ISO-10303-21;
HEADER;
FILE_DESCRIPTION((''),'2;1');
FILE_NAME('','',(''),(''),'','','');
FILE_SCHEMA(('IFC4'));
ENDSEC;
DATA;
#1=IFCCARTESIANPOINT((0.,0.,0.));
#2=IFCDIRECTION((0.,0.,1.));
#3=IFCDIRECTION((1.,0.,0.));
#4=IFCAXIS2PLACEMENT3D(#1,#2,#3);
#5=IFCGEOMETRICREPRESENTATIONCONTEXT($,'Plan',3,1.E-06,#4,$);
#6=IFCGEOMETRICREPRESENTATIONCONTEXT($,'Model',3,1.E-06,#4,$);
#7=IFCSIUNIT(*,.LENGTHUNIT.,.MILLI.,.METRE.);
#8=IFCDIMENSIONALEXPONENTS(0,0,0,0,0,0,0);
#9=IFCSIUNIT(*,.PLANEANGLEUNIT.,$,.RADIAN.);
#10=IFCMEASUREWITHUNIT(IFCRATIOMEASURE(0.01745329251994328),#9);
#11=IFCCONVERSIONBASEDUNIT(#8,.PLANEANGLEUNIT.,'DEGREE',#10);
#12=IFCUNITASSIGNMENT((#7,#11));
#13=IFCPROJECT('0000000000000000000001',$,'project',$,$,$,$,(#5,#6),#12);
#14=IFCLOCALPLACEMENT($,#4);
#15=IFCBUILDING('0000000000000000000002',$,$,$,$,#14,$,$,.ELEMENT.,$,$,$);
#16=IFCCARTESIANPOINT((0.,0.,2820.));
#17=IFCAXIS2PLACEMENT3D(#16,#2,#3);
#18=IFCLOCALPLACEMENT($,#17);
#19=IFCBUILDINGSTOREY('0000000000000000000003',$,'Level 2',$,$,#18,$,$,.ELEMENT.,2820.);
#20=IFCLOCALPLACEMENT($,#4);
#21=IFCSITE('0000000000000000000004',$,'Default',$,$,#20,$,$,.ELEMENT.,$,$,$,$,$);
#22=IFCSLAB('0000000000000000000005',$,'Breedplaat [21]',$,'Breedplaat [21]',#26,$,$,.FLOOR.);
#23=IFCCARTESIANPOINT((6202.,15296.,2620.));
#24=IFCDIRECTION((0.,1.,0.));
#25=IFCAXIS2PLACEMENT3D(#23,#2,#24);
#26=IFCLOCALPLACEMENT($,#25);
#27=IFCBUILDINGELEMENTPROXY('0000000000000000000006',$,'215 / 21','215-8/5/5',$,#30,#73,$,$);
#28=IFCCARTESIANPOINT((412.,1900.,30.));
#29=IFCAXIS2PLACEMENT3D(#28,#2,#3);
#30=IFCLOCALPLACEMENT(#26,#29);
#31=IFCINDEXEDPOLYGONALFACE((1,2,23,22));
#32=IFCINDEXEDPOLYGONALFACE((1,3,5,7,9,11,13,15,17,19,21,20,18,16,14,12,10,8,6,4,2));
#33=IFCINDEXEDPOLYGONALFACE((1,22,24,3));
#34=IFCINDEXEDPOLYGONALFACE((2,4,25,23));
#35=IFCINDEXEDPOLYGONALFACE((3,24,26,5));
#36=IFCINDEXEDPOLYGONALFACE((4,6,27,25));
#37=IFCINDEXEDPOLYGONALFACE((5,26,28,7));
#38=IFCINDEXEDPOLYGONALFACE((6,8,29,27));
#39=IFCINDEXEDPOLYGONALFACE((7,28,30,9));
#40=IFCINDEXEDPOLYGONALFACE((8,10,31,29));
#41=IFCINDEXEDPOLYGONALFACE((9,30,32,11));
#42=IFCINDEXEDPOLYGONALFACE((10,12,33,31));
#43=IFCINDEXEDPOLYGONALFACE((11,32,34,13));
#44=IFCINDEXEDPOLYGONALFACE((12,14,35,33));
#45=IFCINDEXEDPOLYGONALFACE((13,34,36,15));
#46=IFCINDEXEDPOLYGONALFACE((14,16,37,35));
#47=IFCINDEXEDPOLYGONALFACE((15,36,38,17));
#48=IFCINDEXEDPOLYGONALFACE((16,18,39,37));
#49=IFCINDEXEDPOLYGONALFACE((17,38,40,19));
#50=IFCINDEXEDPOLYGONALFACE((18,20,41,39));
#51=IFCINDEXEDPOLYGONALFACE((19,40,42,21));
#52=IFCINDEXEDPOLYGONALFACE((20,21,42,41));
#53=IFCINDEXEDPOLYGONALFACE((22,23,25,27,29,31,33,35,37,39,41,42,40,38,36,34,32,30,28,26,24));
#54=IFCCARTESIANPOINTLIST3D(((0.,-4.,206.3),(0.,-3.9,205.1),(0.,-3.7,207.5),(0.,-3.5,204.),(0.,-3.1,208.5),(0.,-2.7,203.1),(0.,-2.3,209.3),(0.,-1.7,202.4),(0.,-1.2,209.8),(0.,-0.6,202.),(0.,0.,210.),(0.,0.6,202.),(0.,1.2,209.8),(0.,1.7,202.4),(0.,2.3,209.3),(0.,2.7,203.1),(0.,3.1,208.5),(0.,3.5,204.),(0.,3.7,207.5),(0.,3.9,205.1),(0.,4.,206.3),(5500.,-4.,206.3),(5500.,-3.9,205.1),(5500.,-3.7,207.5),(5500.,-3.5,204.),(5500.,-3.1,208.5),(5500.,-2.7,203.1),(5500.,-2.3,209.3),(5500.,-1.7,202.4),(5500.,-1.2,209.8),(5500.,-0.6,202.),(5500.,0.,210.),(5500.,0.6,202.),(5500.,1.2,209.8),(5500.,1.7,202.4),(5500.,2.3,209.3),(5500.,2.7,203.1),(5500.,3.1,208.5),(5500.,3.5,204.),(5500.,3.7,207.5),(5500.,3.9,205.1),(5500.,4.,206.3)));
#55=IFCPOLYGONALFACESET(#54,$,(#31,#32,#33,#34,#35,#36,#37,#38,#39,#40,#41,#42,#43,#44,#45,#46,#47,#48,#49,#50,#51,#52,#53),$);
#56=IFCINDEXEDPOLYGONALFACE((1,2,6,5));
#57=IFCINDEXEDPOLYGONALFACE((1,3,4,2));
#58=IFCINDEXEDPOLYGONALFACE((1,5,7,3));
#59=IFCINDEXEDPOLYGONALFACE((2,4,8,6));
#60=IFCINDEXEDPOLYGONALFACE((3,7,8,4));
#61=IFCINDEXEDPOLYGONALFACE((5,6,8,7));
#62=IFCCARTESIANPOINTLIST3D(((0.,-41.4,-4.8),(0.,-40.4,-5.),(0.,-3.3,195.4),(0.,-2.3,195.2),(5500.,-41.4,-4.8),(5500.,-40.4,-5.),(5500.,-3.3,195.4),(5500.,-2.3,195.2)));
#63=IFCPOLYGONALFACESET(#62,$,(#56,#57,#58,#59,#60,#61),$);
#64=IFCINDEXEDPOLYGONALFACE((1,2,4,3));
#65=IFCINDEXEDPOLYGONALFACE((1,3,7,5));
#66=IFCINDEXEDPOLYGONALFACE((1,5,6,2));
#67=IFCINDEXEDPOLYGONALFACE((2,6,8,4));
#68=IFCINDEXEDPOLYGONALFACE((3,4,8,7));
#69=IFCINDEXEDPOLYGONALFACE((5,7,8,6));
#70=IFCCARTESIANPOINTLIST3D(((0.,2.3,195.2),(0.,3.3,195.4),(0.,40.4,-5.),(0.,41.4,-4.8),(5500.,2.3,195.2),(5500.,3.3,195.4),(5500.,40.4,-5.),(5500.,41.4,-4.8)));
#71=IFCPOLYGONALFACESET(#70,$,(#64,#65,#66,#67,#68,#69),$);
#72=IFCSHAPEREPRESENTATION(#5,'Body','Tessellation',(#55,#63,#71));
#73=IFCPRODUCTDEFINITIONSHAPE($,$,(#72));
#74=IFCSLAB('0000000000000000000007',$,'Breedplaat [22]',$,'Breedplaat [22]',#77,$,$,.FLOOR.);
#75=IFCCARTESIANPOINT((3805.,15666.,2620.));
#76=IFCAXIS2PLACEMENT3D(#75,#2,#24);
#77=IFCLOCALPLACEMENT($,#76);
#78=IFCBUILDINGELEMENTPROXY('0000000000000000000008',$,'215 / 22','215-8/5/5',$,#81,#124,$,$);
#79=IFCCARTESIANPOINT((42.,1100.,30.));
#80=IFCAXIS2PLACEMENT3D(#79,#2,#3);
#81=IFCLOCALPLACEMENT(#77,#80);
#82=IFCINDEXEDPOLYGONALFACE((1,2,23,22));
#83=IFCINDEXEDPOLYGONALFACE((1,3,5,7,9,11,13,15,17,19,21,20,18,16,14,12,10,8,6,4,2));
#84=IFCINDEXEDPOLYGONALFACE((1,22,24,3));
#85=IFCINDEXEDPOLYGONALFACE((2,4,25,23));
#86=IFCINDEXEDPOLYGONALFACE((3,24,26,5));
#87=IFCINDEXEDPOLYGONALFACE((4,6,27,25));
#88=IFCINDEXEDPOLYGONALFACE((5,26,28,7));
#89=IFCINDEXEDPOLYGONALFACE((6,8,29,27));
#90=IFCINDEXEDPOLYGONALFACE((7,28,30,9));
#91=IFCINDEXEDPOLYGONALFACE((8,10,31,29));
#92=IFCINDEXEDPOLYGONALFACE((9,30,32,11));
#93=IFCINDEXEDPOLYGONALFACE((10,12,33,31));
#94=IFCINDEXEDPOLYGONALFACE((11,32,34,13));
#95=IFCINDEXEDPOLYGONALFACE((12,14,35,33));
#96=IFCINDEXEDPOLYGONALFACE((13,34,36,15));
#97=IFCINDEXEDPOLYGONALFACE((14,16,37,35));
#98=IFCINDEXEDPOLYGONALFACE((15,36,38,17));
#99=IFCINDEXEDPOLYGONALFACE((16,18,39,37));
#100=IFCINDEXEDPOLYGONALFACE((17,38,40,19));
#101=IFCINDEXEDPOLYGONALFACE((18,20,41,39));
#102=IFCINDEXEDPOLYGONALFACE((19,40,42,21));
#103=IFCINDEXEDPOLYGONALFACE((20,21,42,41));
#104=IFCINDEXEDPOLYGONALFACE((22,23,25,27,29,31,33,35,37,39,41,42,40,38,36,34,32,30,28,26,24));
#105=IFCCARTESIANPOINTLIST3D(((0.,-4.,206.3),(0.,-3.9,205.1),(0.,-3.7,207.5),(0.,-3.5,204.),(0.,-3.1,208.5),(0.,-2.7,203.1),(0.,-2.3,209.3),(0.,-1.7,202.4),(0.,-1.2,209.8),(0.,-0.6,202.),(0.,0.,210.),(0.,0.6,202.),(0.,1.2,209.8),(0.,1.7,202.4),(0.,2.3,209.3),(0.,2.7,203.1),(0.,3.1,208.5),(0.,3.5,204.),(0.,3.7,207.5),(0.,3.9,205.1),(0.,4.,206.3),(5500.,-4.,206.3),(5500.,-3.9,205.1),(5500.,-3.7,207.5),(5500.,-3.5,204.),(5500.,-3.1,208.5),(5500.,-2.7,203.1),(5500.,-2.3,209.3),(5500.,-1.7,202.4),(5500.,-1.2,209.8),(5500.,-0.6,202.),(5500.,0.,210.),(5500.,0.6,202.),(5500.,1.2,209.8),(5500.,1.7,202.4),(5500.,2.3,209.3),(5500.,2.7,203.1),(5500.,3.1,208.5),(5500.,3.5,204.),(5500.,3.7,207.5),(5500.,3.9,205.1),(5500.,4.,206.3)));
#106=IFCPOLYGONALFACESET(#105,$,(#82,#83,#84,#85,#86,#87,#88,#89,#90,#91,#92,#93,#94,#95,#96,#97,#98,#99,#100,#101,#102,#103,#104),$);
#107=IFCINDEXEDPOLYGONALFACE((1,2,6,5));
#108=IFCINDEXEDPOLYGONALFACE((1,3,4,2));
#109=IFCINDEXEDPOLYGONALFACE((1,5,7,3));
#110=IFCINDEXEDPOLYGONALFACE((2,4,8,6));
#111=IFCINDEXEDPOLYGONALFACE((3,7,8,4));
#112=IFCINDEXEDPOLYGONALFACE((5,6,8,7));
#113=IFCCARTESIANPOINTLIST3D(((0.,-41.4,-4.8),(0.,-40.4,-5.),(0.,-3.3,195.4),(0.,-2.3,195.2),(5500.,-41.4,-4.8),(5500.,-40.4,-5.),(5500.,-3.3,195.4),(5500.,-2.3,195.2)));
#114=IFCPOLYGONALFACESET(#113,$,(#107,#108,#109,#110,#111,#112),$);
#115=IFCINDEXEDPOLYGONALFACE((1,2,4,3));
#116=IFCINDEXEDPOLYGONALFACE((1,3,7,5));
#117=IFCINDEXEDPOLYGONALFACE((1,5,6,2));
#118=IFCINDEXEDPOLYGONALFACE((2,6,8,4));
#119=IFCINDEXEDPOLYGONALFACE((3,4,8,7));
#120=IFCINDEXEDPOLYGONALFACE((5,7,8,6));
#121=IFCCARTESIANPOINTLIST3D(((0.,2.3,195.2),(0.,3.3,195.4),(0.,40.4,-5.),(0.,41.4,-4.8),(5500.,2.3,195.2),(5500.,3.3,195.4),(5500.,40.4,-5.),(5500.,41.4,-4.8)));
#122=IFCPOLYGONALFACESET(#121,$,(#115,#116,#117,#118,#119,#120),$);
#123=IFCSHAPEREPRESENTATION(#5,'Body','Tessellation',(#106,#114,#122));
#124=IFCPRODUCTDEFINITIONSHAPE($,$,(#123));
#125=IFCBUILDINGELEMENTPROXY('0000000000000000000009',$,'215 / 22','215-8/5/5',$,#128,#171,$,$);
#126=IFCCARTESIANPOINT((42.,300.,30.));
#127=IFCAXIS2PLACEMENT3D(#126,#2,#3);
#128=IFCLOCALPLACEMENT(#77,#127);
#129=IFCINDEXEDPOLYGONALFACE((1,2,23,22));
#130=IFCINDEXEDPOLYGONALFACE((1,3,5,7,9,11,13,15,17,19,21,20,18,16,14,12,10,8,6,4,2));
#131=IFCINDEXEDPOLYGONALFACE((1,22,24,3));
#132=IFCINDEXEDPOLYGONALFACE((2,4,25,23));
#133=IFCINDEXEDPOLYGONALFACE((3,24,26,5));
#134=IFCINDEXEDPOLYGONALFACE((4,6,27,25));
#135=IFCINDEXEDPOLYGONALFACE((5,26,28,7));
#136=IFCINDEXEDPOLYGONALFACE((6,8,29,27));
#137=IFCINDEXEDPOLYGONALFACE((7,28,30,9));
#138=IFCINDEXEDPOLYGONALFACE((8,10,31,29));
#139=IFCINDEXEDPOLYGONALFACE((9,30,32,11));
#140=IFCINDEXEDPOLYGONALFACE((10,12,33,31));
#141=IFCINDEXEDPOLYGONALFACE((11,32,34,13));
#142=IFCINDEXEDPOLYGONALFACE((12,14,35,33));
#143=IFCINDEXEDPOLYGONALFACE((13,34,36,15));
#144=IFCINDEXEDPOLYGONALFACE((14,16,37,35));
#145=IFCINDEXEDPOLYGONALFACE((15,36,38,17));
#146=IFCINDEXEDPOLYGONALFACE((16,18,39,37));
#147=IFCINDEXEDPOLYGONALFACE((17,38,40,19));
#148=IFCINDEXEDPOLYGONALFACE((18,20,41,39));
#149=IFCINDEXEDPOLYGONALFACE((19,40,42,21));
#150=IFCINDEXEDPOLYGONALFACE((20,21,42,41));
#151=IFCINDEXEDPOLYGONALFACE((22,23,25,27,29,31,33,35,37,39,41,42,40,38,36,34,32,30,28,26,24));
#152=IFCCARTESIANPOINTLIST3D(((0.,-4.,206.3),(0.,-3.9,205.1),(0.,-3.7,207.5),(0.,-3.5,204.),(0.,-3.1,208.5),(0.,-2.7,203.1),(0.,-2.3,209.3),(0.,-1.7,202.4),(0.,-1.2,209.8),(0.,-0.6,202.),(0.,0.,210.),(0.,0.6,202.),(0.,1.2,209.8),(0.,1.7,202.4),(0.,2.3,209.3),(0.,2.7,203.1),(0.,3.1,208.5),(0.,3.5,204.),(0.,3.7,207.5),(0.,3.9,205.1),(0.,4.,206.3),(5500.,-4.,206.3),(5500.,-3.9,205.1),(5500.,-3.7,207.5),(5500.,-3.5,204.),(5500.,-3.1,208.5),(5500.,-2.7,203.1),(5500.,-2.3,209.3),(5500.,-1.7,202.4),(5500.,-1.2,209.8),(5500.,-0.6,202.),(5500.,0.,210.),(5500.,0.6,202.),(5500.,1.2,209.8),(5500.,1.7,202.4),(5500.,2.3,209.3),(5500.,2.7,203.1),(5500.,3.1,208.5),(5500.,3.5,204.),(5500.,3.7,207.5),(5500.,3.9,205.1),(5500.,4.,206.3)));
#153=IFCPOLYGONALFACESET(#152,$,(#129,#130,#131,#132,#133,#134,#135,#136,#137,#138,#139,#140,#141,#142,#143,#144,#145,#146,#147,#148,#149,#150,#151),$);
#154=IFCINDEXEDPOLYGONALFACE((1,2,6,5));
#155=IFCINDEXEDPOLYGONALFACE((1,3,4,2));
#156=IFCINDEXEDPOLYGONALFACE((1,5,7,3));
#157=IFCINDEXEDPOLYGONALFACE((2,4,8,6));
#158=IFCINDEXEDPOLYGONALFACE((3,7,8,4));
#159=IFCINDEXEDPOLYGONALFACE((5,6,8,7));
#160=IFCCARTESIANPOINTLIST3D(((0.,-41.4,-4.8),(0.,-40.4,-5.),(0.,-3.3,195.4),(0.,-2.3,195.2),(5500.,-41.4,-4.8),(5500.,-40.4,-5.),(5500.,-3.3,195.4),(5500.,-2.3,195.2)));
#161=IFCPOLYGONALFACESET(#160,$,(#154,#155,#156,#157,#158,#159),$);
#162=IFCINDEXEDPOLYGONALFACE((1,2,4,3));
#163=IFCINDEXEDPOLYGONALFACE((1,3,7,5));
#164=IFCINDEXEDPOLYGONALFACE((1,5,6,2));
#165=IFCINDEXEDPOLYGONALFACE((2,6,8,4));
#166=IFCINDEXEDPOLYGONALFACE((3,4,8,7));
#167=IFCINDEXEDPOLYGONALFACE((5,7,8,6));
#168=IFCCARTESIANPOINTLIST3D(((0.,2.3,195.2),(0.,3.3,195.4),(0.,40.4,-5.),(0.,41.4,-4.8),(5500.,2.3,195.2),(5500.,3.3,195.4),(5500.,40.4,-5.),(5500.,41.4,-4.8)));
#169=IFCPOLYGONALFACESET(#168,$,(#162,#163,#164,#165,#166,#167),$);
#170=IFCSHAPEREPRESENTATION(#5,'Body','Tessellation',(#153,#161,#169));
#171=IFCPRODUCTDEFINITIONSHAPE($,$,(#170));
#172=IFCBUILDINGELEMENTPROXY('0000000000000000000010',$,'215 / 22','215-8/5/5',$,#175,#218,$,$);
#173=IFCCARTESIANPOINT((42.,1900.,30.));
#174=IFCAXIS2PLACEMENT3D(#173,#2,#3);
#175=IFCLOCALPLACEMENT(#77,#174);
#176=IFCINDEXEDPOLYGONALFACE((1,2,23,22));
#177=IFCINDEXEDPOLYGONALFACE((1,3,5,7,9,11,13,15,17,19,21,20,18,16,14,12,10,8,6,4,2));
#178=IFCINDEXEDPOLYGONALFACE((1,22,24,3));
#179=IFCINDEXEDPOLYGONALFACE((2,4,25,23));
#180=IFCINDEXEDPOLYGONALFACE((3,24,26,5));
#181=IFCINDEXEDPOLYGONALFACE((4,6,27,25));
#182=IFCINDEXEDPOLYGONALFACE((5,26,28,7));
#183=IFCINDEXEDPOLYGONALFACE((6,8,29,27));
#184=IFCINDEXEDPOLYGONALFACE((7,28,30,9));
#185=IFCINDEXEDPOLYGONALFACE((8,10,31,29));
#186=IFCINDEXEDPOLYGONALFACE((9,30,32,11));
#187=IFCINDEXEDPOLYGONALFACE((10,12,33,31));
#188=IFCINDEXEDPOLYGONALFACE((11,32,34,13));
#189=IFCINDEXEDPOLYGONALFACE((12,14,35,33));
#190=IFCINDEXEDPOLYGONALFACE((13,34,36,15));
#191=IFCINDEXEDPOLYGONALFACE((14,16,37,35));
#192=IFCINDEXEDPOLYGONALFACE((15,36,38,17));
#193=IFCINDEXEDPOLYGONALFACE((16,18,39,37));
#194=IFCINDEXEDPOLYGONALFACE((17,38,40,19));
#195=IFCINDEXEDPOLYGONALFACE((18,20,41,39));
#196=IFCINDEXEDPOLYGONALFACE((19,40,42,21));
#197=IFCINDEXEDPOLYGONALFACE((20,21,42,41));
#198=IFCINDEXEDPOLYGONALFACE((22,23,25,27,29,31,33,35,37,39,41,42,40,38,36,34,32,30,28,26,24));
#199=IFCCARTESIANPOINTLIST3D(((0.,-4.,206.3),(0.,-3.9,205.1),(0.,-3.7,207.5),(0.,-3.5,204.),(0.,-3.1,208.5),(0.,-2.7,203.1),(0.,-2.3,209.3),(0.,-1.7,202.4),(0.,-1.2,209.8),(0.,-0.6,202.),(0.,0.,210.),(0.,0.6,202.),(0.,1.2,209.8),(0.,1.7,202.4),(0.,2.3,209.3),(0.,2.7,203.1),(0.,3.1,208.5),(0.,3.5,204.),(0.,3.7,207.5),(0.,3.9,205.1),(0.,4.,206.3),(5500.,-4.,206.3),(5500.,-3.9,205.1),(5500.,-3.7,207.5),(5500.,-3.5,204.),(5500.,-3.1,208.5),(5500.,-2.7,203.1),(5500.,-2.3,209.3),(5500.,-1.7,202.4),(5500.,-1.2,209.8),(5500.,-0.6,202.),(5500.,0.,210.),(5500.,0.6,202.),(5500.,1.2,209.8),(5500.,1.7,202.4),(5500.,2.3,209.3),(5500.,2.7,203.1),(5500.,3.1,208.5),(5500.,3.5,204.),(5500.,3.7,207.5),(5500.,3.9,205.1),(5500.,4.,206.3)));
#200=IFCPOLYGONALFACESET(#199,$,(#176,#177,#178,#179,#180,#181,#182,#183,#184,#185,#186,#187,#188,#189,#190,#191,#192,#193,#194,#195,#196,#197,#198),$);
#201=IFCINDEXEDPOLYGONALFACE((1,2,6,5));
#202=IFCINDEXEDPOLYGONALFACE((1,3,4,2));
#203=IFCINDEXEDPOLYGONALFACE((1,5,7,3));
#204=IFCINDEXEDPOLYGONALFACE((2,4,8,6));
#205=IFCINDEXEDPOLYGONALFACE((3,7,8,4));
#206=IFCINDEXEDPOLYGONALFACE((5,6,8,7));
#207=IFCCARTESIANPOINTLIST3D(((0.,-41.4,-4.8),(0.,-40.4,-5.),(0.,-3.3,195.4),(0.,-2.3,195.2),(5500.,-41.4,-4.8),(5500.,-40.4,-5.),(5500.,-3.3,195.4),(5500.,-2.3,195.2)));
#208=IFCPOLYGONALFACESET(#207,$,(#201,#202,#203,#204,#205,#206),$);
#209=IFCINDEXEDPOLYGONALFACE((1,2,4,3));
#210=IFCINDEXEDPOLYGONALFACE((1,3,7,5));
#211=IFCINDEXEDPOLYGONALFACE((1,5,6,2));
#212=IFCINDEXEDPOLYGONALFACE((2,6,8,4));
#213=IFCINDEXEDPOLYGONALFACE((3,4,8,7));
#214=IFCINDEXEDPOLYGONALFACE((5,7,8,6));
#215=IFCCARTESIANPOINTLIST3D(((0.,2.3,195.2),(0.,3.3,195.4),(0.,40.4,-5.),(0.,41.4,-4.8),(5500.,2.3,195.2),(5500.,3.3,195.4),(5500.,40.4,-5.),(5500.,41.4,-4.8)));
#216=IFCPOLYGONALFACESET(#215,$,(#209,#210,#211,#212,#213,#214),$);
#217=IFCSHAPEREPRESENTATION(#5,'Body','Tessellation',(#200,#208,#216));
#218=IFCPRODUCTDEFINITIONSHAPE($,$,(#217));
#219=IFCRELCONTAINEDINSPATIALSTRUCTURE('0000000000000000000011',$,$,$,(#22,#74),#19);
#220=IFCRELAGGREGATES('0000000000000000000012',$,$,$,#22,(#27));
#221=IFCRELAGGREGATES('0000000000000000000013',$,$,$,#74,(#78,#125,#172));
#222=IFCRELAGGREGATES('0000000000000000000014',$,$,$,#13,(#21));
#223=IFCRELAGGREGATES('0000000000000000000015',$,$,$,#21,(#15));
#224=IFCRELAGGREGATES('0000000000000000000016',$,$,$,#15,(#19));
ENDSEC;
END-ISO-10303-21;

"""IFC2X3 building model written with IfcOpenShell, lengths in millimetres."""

from ifc_helpers import new_model, entity, si_unit, converted_unit, frame, origin_with_axes, origin_2d_with_axis, place, context, project, spatial, rectangle, circle, extrude, element, aggregate, save


model = new_model("IFC2X3")

# Units and contexts
plan_context = context("Plan", 3, precision=1e-06, world=origin_with_axes())
model_context = context("Model", 3, precision=1e-06, world=origin_with_axes())
ifc_project = project(units=[si_unit("LENGTHUNIT", "METRE", prefix="MILLI"), converted_unit("PLANEANGLEUNIT", "DEGREE", entity("IfcRatioMeasure", 0.01745329251994328), si_unit("PLANEANGLEUNIT", "RADIAN"), dimensions=[0, 0, 0, 0, 0, 0, 0])], contexts=[plan_context, model_context])

# Site, building, storey
site_placement = place(None, origin_with_axes())
site = spatial("IfcSite", under=ifc_project, at=site_placement, Name="Default", CompositionType="ELEMENT")
building_placement = place(None, origin_with_axes())
building = spatial("IfcBuilding", under=site, at=building_placement, CompositionType="ELEMENT")
storey_placement = place(None, frame((0.0, 0.0, 2820.0), z_axis=(0.0, 0.0, 1.0), x_axis=(1.0, 0.0, 0.0)))
storey = spatial("IfcBuildingStorey", under=building, at=storey_placement, Name="Level 2", CompositionType="ELEMENT", Elevation=2820.0)

# Slabs, building element proxies
slab_1_placement = place(None, frame((6202.0, 15296.0, 2620.0), z_axis=(0.0, 0.0, 1.0), x_axis=(0.0, 1.0, 0.0)))
slab_1 = element("IfcSlab", 1, at=slab_1_placement, inside=storey, Name="Breedplaat [21]", ObjectType="Breedplaat [21]", PredefinedType="FLOOR")
proxy_1_placement = place(slab_1_placement, frame((412.0, 1900.0, 30.0), z_axis=(0.0, 0.0, 1.0), x_axis=(1.0, 0.0, 0.0)))
proxy_1 = element("IfcBuildingElementProxy", 2, at=proxy_1_placement, Name="215 / 21", Description="215-8/5/5", context=plan_context, shape_type="SweptSolid", body=[
    extrude(circle(Radius=4.0, at=origin_2d_with_axis()), frame((0.0, 0.0, 206.0), z_axis=(1.0, 0.0, 0.0), x_axis=(0.0, 0.0, 1.0)), (0.0, 0.0, 1.0), 5500.0),
    extrude(rectangle(XDim=203.8, YDim=1.0, at=origin_2d_with_axis()), frame((0.0, -21.9, 95.2), z_axis=(1.0, 0.0, 0.0), x_axis=(0.0, 0.187112, 0.982339)), (0.0, 0.0, 1.0), 5500.0),
    extrude(rectangle(XDim=203.8, YDim=1.0, at=origin_2d_with_axis()), frame((0.0, 21.9, 95.2), z_axis=(1.0, 0.0, 0.0), x_axis=(0.0, -0.187112, 0.982339)), (0.0, 0.0, 1.0), 5500.0),
])
aggregate(slab_1, [proxy_1])
slab_2_placement = place(None, frame((3805.0, 15666.0, 2620.0), z_axis=(0.0, 0.0, 1.0), x_axis=(0.0, 1.0, 0.0)))
slab_2 = element("IfcSlab", 3, at=slab_2_placement, inside=storey, Name="Breedplaat [22]", ObjectType="Breedplaat [22]", PredefinedType="FLOOR")
proxy_2_placement = place(slab_2_placement, frame((42.0, 1100.0, 30.0), z_axis=(0.0, 0.0, 1.0), x_axis=(1.0, 0.0, 0.0)))
proxy_2 = element("IfcBuildingElementProxy", 4, at=proxy_2_placement, Name="215 / 22", Description="215-8/5/5", context=plan_context, shape_type="SweptSolid", body=[
    extrude(circle(Radius=4.0, at=origin_2d_with_axis()), frame((0.0, 0.0, 206.0), z_axis=(1.0, 0.0, 0.0), x_axis=(0.0, 0.0, 1.0)), (0.0, 0.0, 1.0), 5500.0),
    extrude(rectangle(XDim=203.8, YDim=1.0, at=origin_2d_with_axis()), frame((0.0, -21.9, 95.2), z_axis=(1.0, 0.0, 0.0), x_axis=(0.0, 0.187112, 0.982339)), (0.0, 0.0, 1.0), 5500.0),
    extrude(rectangle(XDim=203.8, YDim=1.0, at=origin_2d_with_axis()), frame((0.0, 21.9, 95.2), z_axis=(1.0, 0.0, 0.0), x_axis=(0.0, -0.187112, 0.982339)), (0.0, 0.0, 1.0), 5500.0),
])
proxy_3_placement = place(slab_2_placement, frame((42.0, 300.0, 30.0), z_axis=(0.0, 0.0, 1.0), x_axis=(1.0, 0.0, 0.0)))
proxy_3 = element("IfcBuildingElementProxy", 5, at=proxy_3_placement, Name="215 / 22", Description="215-8/5/5", context=plan_context, shape_type="SweptSolid", body=[
    extrude(circle(Radius=4.0, at=origin_2d_with_axis()), frame((0.0, 0.0, 206.0), z_axis=(1.0, 0.0, 0.0), x_axis=(0.0, 0.0, 1.0)), (0.0, 0.0, 1.0), 5500.0),
    extrude(rectangle(XDim=203.8, YDim=1.0, at=origin_2d_with_axis()), frame((0.0, -21.9, 95.2), z_axis=(1.0, 0.0, 0.0), x_axis=(0.0, 0.187112, 0.982339)), (0.0, 0.0, 1.0), 5500.0),
    extrude(rectangle(XDim=203.8, YDim=1.0, at=origin_2d_with_axis()), frame((0.0, 21.9, 95.2), z_axis=(1.0, 0.0, 0.0), x_axis=(0.0, -0.187112, 0.982339)), (0.0, 0.0, 1.0), 5500.0),
])
proxy_4_placement = place(slab_2_placement, frame((42.0, 1900.0, 30.0), z_axis=(0.0, 0.0, 1.0), x_axis=(1.0, 0.0, 0.0)))
proxy_4 = element("IfcBuildingElementProxy", 6, at=proxy_4_placement, Name="215 / 22", Description="215-8/5/5", context=plan_context, shape_type="SweptSolid", body=[
    extrude(circle(Radius=4.0, at=origin_2d_with_axis()), frame((0.0, 0.0, 206.0), z_axis=(1.0, 0.0, 0.0), x_axis=(0.0, 0.0, 1.0)), (0.0, 0.0, 1.0), 5500.0),
    extrude(rectangle(XDim=203.8, YDim=1.0, at=origin_2d_with_axis()), frame((0.0, -21.9, 95.2), z_axis=(1.0, 0.0, 0.0), x_axis=(0.0, 0.187112, 0.982339)), (0.0, 0.0, 1.0), 5500.0),
    extrude(rectangle(XDim=203.8, YDim=1.0, at=origin_2d_with_axis()), frame((0.0, 21.9, 95.2), z_axis=(1.0, 0.0, 0.0), x_axis=(0.0, -0.187112, 0.982339)), (0.0, 0.0, 1.0), 5500.0),
])
aggregate(slab_2, [proxy_2, proxy_3, proxy_4])

save(model, "model.ifc")
